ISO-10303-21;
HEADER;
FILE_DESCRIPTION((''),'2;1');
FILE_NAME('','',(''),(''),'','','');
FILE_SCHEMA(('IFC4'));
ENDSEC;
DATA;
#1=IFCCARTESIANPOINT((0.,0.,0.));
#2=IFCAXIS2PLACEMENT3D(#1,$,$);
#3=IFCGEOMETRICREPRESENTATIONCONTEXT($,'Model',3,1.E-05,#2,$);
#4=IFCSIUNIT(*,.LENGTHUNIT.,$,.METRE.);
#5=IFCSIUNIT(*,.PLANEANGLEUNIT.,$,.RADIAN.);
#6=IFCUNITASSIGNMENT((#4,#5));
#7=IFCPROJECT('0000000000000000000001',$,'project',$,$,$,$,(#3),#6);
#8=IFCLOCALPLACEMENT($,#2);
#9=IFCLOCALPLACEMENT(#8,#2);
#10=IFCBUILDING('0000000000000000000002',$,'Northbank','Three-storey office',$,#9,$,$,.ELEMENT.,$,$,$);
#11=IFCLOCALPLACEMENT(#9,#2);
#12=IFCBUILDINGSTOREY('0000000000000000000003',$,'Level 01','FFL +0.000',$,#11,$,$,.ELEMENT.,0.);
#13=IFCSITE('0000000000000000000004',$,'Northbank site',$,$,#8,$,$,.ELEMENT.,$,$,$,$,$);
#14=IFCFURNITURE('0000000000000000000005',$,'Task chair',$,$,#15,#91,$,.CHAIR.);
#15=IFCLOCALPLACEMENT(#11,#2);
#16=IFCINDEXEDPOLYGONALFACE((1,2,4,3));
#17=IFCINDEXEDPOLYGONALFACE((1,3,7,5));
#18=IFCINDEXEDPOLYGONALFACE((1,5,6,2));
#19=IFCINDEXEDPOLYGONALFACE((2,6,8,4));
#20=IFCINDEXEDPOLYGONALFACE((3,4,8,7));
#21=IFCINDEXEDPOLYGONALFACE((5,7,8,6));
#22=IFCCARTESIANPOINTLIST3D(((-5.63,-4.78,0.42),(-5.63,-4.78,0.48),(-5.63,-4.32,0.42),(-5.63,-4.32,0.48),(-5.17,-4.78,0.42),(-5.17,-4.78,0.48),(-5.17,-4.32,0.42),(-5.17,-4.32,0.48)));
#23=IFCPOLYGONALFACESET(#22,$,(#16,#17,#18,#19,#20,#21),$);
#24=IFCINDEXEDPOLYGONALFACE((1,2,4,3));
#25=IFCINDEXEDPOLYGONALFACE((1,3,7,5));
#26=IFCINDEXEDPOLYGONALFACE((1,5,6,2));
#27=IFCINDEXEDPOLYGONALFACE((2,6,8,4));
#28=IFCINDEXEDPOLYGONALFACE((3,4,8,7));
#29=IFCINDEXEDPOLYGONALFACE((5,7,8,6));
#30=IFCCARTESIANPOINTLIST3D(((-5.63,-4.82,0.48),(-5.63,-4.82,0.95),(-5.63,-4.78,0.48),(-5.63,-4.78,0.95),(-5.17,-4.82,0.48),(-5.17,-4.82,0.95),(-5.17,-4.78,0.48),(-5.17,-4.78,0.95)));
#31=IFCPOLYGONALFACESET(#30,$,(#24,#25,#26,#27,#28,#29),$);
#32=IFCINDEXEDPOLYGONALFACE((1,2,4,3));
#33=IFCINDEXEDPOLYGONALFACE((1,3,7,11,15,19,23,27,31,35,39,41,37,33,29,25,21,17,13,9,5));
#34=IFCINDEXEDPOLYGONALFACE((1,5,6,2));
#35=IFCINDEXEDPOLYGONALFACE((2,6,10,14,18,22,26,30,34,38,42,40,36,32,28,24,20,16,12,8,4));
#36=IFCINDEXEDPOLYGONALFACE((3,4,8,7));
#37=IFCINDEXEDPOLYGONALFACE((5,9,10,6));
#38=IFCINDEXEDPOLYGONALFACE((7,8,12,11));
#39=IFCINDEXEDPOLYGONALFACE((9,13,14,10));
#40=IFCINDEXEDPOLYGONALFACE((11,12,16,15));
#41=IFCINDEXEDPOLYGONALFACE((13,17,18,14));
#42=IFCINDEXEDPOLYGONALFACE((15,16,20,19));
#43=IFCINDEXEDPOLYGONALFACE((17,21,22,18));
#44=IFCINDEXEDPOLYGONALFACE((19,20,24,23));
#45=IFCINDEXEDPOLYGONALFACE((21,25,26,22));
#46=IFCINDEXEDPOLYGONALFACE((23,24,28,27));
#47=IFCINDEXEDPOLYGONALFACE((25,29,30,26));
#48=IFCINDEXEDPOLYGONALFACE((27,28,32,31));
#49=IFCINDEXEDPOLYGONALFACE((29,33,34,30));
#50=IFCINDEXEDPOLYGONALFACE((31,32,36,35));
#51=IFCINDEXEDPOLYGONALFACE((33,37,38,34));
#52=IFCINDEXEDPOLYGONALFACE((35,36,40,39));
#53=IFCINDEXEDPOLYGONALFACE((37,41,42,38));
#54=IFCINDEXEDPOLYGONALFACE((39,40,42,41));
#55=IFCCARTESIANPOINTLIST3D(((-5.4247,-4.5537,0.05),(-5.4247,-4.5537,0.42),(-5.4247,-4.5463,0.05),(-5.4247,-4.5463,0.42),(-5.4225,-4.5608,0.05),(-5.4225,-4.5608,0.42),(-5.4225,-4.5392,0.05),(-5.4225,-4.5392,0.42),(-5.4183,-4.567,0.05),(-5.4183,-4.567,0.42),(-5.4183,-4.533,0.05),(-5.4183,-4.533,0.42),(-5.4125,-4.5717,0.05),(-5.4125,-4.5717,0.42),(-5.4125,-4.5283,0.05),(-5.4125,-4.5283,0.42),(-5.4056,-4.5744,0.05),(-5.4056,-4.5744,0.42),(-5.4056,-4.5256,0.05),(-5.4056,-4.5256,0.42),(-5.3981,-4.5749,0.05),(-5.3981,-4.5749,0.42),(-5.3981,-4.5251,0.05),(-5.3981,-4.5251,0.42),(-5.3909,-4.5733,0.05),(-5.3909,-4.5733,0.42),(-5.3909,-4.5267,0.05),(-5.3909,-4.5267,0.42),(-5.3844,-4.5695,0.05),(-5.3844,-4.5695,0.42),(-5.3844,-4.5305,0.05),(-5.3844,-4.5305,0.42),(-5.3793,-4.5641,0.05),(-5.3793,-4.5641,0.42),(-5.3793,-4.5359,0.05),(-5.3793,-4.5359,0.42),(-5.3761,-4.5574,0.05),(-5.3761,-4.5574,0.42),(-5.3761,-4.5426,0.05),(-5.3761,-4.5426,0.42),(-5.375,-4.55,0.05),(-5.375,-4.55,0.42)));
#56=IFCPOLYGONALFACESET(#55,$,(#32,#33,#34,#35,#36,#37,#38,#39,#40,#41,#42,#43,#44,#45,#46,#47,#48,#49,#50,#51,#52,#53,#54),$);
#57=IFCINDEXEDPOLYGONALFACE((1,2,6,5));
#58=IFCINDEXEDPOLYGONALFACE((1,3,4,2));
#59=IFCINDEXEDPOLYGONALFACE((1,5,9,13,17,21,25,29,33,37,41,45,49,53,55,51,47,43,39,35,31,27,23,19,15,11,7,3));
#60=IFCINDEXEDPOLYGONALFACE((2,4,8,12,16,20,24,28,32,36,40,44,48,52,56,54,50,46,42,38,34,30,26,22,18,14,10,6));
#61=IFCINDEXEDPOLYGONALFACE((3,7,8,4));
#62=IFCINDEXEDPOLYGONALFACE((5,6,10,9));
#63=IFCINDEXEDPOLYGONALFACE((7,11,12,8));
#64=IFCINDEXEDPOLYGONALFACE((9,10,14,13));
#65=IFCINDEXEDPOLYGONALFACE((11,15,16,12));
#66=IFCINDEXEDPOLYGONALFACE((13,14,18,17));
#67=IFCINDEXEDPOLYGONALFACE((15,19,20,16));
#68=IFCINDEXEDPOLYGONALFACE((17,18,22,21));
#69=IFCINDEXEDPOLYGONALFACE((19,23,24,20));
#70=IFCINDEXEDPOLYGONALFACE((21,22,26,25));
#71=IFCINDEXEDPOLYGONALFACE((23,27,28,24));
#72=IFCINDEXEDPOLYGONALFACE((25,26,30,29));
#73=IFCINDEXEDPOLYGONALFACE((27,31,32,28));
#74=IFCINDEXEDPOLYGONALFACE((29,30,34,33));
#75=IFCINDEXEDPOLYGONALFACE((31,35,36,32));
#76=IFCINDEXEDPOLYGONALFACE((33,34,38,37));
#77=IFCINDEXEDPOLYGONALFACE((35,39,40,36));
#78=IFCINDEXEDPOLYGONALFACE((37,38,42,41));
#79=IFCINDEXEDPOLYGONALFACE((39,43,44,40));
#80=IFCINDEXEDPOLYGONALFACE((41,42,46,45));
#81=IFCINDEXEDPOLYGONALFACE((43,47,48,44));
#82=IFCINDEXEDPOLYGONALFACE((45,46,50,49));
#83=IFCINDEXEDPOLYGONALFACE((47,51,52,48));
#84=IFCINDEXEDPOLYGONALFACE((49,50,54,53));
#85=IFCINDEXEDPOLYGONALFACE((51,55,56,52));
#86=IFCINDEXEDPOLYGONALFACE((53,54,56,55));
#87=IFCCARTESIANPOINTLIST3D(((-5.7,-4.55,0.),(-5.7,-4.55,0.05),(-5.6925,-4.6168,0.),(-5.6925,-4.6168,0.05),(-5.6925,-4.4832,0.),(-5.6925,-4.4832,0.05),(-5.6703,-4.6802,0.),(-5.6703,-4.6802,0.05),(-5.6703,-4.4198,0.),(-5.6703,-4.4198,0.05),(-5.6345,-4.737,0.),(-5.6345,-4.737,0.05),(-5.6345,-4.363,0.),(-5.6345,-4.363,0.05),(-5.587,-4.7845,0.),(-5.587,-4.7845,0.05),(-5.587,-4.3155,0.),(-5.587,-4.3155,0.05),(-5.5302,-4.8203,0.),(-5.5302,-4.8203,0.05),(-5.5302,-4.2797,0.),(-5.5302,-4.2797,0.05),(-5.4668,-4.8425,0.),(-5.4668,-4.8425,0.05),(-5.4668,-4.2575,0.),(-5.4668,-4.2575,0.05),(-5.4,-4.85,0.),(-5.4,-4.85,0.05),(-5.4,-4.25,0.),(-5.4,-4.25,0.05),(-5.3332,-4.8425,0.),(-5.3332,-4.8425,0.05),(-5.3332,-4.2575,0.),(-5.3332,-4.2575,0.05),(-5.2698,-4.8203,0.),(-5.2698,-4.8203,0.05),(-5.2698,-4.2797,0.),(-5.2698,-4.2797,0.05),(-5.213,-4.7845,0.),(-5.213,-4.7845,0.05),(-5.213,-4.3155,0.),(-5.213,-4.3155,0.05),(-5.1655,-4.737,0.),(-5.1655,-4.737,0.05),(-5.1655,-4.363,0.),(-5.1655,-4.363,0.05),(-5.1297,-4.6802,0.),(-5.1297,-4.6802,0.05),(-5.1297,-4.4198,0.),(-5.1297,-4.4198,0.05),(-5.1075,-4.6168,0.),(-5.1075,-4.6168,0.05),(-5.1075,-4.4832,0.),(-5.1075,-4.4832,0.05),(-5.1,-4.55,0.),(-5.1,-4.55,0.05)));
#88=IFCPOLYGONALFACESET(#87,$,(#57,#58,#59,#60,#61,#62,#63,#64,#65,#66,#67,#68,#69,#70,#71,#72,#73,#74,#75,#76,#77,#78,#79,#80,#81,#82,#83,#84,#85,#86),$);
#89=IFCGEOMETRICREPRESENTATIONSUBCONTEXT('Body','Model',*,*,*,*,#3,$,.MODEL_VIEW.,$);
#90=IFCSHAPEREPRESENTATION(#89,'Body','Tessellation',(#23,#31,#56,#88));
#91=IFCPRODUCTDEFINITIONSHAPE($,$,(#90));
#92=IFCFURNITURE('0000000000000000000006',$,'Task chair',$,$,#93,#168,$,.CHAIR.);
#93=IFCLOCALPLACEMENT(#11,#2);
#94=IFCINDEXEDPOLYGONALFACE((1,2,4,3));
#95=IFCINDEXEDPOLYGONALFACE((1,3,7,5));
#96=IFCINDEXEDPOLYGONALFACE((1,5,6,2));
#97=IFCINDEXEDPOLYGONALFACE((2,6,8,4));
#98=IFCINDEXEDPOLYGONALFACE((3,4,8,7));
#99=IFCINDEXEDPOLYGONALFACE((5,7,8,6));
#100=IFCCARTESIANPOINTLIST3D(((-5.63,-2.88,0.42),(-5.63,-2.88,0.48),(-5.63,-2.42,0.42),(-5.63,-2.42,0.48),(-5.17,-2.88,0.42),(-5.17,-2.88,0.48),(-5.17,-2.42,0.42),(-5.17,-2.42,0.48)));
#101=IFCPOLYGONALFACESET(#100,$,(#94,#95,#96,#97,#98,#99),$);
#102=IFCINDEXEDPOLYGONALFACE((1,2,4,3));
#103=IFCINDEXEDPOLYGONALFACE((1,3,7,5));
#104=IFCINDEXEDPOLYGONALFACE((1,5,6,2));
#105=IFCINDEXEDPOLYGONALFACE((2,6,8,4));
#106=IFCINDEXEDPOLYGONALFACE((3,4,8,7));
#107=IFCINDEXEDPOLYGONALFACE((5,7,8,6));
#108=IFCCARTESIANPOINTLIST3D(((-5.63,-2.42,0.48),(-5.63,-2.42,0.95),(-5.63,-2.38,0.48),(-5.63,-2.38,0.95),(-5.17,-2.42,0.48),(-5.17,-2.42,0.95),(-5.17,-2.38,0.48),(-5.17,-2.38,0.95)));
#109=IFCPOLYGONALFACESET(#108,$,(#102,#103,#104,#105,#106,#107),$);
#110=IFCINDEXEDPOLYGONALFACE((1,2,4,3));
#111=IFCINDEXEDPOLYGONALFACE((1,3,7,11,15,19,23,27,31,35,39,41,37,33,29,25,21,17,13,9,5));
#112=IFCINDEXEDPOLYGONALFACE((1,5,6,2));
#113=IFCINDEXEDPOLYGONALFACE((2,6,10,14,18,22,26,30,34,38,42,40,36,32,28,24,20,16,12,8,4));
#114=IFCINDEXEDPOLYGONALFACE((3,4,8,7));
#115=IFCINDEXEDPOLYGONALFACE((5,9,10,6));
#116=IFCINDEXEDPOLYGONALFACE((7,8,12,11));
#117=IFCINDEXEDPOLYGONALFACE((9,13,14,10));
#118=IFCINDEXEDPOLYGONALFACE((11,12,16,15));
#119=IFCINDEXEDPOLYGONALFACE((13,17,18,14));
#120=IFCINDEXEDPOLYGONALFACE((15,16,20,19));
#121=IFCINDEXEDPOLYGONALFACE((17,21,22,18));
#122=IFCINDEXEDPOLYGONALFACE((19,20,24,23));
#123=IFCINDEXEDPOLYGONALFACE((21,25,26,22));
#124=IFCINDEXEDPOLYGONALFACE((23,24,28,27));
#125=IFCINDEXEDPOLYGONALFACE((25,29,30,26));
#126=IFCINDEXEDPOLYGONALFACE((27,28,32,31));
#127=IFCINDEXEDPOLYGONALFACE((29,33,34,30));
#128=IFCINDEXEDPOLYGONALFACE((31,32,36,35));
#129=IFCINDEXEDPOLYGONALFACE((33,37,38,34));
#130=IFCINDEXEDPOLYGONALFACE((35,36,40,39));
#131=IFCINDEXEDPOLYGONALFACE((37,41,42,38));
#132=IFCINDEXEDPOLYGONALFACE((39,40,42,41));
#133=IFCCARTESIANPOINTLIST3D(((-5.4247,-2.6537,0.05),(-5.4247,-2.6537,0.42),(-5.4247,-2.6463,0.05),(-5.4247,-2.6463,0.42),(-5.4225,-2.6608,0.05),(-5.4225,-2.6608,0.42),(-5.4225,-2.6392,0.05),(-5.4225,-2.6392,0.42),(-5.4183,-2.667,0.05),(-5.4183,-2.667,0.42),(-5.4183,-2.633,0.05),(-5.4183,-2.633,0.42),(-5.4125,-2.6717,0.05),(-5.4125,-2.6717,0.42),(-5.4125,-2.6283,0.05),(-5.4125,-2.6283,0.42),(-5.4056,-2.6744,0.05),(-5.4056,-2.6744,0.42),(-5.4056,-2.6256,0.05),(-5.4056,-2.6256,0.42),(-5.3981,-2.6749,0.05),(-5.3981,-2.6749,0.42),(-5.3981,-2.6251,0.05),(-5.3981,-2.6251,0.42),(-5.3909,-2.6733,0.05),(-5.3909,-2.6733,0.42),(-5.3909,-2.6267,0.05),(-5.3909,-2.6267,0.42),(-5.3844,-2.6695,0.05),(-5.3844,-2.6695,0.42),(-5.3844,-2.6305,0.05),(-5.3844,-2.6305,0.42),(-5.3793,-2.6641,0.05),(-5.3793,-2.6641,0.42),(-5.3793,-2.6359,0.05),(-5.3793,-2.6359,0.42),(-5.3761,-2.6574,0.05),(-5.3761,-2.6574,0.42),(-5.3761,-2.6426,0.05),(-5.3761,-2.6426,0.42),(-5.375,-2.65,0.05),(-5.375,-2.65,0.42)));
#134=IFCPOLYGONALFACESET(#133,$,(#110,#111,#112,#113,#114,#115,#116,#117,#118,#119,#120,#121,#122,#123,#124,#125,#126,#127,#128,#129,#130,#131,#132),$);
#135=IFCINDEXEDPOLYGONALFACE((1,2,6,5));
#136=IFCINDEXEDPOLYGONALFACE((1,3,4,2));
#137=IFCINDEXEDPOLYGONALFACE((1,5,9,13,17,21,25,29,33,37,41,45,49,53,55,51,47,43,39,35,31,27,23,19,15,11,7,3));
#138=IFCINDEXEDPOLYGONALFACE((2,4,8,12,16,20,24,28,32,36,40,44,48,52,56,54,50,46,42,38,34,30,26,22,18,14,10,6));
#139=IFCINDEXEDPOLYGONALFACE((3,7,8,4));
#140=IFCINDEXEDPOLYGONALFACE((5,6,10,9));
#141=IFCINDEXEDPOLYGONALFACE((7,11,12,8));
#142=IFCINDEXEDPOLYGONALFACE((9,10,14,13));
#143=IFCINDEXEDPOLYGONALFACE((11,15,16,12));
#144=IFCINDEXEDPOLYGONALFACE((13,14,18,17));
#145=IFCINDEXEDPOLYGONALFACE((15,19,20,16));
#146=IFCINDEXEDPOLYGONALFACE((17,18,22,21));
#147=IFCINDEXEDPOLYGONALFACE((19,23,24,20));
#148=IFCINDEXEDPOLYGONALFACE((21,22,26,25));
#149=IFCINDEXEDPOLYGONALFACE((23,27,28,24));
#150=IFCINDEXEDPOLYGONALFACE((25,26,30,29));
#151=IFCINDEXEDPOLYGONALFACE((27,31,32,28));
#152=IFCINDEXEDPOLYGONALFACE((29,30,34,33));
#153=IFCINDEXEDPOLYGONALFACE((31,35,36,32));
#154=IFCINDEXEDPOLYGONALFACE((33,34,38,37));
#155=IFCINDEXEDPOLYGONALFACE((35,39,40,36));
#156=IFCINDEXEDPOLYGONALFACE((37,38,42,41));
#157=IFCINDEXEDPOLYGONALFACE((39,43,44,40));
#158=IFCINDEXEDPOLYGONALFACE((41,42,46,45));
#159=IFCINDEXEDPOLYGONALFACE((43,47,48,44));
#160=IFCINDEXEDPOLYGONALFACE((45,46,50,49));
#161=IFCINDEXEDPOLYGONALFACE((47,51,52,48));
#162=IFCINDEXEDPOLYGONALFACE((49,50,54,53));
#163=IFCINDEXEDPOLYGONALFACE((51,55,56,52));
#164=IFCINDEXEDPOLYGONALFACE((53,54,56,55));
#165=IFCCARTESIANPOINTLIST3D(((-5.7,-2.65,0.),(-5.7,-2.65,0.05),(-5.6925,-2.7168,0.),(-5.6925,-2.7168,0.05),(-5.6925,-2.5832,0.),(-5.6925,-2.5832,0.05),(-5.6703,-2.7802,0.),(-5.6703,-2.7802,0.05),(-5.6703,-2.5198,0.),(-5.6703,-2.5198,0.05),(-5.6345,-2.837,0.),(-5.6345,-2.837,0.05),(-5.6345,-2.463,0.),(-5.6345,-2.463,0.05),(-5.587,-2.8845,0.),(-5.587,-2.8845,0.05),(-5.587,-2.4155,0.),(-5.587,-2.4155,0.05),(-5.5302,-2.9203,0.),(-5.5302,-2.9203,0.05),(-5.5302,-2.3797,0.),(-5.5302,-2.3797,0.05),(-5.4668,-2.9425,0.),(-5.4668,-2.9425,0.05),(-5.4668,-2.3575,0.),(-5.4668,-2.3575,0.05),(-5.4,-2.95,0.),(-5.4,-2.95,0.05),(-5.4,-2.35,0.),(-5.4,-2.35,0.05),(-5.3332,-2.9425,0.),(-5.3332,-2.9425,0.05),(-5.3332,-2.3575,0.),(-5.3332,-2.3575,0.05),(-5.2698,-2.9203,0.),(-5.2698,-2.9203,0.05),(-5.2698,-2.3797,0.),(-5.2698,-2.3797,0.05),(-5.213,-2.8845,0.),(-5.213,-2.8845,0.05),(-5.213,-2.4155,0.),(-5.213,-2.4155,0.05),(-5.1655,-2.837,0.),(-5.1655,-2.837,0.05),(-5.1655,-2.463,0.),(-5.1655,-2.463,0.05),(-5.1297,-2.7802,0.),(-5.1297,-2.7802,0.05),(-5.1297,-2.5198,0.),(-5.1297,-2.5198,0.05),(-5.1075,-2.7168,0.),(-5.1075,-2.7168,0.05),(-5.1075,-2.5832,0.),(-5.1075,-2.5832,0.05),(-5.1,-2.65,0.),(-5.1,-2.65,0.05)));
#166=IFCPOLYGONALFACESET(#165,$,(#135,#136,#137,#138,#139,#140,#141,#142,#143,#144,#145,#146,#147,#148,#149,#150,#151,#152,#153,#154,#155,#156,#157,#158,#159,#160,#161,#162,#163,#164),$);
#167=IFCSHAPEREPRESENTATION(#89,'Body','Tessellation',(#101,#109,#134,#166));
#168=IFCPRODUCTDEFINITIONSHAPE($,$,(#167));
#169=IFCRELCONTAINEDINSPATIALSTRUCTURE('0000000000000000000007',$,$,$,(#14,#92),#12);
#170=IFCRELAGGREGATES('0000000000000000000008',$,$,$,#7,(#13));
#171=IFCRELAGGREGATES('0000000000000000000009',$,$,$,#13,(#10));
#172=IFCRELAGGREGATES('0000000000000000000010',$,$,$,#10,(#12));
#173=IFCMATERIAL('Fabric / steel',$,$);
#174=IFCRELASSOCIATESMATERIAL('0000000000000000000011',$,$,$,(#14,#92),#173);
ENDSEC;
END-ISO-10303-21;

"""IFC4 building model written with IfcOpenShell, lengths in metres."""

from ifc_helpers import new_model, si_unit, frame, origin, place, context, subcontext, project, spatial, rectangle, circle, extrude, material, element, save


model = new_model("IFC4")

# Units and contexts
model_context = context("Model", 3, precision=1e-05, world=origin())
body_context = subcontext(model_context, "Body", "Model", "MODEL_VIEW")
ifc_project = project(units=[si_unit("LENGTHUNIT", "METRE"), si_unit("PLANEANGLEUNIT", "RADIAN")], contexts=[model_context])

# Site, building, storey
site_placement = place(None, origin())
site = spatial("IfcSite", under=ifc_project, at=site_placement, Name="Northbank site", CompositionType="ELEMENT")
building_placement = place(site_placement, origin())
building = spatial("IfcBuilding", under=site, at=building_placement, Name="Northbank", Description="Three-storey office", CompositionType="ELEMENT")
storey_placement = place(building_placement, origin())
storey = spatial("IfcBuildingStorey", under=building, at=storey_placement, Name="Level 01", Description="FFL +0.000", CompositionType="ELEMENT", Elevation=0.0)

# Furniture
ifc_material_1 = material(Name="Fabric / steel")
furniture_1_placement = place(storey_placement, origin())
element("IfcFurniture", 1, at=furniture_1_placement, inside=storey, material=ifc_material_1, Name="Task chair", PredefinedType="CHAIR", context=body_context, shape_type="SweptSolid", body=[
    extrude(rectangle(XDim=0.46, YDim=0.46), frame((-5.4, -4.55, 0.42)), (0.0, 0.0, 1.0), 0.06),
    extrude(rectangle(XDim=0.46, YDim=0.04), frame((-5.4, -4.8, 0.48)), (0.0, 0.0, 1.0), 0.47),
    extrude(circle(Radius=0.025), frame((-5.4, -4.55, 0.05), z_axis=(0.0, 0.0, 1.0), x_axis=(1.0, 0.0, 0.0)), (0.0, 0.0, 1.0), 0.37),
    extrude(circle(Radius=0.3), frame((-5.4, -4.55, 0.0), z_axis=(0.0, 0.0, 1.0), x_axis=(1.0, 0.0, 0.0)), (0.0, 0.0, 1.0), 0.05),
])
furniture_2_placement = place(storey_placement, origin())
element("IfcFurniture", 2, at=furniture_2_placement, inside=storey, material=ifc_material_1, Name="Task chair", PredefinedType="CHAIR", context=body_context, shape_type="SweptSolid", body=[
    extrude(rectangle(XDim=0.46, YDim=0.46), frame((-5.4, -2.65, 0.42)), (0.0, 0.0, 1.0), 0.06),
    extrude(rectangle(XDim=0.46, YDim=0.04), frame((-5.4, -2.4, 0.48)), (0.0, 0.0, 1.0), 0.47),
    extrude(circle(Radius=0.025), frame((-5.4, -2.65, 0.05), z_axis=(0.0, 0.0, 1.0), x_axis=(1.0, 0.0, 0.0)), (0.0, 0.0, 1.0), 0.37),
    extrude(circle(Radius=0.3), frame((-5.4, -2.65, 0.0), z_axis=(0.0, 0.0, 1.0), x_axis=(1.0, 0.0, 0.0)), (0.0, 0.0, 1.0), 0.05),
])

save(model, "model.ifc")
